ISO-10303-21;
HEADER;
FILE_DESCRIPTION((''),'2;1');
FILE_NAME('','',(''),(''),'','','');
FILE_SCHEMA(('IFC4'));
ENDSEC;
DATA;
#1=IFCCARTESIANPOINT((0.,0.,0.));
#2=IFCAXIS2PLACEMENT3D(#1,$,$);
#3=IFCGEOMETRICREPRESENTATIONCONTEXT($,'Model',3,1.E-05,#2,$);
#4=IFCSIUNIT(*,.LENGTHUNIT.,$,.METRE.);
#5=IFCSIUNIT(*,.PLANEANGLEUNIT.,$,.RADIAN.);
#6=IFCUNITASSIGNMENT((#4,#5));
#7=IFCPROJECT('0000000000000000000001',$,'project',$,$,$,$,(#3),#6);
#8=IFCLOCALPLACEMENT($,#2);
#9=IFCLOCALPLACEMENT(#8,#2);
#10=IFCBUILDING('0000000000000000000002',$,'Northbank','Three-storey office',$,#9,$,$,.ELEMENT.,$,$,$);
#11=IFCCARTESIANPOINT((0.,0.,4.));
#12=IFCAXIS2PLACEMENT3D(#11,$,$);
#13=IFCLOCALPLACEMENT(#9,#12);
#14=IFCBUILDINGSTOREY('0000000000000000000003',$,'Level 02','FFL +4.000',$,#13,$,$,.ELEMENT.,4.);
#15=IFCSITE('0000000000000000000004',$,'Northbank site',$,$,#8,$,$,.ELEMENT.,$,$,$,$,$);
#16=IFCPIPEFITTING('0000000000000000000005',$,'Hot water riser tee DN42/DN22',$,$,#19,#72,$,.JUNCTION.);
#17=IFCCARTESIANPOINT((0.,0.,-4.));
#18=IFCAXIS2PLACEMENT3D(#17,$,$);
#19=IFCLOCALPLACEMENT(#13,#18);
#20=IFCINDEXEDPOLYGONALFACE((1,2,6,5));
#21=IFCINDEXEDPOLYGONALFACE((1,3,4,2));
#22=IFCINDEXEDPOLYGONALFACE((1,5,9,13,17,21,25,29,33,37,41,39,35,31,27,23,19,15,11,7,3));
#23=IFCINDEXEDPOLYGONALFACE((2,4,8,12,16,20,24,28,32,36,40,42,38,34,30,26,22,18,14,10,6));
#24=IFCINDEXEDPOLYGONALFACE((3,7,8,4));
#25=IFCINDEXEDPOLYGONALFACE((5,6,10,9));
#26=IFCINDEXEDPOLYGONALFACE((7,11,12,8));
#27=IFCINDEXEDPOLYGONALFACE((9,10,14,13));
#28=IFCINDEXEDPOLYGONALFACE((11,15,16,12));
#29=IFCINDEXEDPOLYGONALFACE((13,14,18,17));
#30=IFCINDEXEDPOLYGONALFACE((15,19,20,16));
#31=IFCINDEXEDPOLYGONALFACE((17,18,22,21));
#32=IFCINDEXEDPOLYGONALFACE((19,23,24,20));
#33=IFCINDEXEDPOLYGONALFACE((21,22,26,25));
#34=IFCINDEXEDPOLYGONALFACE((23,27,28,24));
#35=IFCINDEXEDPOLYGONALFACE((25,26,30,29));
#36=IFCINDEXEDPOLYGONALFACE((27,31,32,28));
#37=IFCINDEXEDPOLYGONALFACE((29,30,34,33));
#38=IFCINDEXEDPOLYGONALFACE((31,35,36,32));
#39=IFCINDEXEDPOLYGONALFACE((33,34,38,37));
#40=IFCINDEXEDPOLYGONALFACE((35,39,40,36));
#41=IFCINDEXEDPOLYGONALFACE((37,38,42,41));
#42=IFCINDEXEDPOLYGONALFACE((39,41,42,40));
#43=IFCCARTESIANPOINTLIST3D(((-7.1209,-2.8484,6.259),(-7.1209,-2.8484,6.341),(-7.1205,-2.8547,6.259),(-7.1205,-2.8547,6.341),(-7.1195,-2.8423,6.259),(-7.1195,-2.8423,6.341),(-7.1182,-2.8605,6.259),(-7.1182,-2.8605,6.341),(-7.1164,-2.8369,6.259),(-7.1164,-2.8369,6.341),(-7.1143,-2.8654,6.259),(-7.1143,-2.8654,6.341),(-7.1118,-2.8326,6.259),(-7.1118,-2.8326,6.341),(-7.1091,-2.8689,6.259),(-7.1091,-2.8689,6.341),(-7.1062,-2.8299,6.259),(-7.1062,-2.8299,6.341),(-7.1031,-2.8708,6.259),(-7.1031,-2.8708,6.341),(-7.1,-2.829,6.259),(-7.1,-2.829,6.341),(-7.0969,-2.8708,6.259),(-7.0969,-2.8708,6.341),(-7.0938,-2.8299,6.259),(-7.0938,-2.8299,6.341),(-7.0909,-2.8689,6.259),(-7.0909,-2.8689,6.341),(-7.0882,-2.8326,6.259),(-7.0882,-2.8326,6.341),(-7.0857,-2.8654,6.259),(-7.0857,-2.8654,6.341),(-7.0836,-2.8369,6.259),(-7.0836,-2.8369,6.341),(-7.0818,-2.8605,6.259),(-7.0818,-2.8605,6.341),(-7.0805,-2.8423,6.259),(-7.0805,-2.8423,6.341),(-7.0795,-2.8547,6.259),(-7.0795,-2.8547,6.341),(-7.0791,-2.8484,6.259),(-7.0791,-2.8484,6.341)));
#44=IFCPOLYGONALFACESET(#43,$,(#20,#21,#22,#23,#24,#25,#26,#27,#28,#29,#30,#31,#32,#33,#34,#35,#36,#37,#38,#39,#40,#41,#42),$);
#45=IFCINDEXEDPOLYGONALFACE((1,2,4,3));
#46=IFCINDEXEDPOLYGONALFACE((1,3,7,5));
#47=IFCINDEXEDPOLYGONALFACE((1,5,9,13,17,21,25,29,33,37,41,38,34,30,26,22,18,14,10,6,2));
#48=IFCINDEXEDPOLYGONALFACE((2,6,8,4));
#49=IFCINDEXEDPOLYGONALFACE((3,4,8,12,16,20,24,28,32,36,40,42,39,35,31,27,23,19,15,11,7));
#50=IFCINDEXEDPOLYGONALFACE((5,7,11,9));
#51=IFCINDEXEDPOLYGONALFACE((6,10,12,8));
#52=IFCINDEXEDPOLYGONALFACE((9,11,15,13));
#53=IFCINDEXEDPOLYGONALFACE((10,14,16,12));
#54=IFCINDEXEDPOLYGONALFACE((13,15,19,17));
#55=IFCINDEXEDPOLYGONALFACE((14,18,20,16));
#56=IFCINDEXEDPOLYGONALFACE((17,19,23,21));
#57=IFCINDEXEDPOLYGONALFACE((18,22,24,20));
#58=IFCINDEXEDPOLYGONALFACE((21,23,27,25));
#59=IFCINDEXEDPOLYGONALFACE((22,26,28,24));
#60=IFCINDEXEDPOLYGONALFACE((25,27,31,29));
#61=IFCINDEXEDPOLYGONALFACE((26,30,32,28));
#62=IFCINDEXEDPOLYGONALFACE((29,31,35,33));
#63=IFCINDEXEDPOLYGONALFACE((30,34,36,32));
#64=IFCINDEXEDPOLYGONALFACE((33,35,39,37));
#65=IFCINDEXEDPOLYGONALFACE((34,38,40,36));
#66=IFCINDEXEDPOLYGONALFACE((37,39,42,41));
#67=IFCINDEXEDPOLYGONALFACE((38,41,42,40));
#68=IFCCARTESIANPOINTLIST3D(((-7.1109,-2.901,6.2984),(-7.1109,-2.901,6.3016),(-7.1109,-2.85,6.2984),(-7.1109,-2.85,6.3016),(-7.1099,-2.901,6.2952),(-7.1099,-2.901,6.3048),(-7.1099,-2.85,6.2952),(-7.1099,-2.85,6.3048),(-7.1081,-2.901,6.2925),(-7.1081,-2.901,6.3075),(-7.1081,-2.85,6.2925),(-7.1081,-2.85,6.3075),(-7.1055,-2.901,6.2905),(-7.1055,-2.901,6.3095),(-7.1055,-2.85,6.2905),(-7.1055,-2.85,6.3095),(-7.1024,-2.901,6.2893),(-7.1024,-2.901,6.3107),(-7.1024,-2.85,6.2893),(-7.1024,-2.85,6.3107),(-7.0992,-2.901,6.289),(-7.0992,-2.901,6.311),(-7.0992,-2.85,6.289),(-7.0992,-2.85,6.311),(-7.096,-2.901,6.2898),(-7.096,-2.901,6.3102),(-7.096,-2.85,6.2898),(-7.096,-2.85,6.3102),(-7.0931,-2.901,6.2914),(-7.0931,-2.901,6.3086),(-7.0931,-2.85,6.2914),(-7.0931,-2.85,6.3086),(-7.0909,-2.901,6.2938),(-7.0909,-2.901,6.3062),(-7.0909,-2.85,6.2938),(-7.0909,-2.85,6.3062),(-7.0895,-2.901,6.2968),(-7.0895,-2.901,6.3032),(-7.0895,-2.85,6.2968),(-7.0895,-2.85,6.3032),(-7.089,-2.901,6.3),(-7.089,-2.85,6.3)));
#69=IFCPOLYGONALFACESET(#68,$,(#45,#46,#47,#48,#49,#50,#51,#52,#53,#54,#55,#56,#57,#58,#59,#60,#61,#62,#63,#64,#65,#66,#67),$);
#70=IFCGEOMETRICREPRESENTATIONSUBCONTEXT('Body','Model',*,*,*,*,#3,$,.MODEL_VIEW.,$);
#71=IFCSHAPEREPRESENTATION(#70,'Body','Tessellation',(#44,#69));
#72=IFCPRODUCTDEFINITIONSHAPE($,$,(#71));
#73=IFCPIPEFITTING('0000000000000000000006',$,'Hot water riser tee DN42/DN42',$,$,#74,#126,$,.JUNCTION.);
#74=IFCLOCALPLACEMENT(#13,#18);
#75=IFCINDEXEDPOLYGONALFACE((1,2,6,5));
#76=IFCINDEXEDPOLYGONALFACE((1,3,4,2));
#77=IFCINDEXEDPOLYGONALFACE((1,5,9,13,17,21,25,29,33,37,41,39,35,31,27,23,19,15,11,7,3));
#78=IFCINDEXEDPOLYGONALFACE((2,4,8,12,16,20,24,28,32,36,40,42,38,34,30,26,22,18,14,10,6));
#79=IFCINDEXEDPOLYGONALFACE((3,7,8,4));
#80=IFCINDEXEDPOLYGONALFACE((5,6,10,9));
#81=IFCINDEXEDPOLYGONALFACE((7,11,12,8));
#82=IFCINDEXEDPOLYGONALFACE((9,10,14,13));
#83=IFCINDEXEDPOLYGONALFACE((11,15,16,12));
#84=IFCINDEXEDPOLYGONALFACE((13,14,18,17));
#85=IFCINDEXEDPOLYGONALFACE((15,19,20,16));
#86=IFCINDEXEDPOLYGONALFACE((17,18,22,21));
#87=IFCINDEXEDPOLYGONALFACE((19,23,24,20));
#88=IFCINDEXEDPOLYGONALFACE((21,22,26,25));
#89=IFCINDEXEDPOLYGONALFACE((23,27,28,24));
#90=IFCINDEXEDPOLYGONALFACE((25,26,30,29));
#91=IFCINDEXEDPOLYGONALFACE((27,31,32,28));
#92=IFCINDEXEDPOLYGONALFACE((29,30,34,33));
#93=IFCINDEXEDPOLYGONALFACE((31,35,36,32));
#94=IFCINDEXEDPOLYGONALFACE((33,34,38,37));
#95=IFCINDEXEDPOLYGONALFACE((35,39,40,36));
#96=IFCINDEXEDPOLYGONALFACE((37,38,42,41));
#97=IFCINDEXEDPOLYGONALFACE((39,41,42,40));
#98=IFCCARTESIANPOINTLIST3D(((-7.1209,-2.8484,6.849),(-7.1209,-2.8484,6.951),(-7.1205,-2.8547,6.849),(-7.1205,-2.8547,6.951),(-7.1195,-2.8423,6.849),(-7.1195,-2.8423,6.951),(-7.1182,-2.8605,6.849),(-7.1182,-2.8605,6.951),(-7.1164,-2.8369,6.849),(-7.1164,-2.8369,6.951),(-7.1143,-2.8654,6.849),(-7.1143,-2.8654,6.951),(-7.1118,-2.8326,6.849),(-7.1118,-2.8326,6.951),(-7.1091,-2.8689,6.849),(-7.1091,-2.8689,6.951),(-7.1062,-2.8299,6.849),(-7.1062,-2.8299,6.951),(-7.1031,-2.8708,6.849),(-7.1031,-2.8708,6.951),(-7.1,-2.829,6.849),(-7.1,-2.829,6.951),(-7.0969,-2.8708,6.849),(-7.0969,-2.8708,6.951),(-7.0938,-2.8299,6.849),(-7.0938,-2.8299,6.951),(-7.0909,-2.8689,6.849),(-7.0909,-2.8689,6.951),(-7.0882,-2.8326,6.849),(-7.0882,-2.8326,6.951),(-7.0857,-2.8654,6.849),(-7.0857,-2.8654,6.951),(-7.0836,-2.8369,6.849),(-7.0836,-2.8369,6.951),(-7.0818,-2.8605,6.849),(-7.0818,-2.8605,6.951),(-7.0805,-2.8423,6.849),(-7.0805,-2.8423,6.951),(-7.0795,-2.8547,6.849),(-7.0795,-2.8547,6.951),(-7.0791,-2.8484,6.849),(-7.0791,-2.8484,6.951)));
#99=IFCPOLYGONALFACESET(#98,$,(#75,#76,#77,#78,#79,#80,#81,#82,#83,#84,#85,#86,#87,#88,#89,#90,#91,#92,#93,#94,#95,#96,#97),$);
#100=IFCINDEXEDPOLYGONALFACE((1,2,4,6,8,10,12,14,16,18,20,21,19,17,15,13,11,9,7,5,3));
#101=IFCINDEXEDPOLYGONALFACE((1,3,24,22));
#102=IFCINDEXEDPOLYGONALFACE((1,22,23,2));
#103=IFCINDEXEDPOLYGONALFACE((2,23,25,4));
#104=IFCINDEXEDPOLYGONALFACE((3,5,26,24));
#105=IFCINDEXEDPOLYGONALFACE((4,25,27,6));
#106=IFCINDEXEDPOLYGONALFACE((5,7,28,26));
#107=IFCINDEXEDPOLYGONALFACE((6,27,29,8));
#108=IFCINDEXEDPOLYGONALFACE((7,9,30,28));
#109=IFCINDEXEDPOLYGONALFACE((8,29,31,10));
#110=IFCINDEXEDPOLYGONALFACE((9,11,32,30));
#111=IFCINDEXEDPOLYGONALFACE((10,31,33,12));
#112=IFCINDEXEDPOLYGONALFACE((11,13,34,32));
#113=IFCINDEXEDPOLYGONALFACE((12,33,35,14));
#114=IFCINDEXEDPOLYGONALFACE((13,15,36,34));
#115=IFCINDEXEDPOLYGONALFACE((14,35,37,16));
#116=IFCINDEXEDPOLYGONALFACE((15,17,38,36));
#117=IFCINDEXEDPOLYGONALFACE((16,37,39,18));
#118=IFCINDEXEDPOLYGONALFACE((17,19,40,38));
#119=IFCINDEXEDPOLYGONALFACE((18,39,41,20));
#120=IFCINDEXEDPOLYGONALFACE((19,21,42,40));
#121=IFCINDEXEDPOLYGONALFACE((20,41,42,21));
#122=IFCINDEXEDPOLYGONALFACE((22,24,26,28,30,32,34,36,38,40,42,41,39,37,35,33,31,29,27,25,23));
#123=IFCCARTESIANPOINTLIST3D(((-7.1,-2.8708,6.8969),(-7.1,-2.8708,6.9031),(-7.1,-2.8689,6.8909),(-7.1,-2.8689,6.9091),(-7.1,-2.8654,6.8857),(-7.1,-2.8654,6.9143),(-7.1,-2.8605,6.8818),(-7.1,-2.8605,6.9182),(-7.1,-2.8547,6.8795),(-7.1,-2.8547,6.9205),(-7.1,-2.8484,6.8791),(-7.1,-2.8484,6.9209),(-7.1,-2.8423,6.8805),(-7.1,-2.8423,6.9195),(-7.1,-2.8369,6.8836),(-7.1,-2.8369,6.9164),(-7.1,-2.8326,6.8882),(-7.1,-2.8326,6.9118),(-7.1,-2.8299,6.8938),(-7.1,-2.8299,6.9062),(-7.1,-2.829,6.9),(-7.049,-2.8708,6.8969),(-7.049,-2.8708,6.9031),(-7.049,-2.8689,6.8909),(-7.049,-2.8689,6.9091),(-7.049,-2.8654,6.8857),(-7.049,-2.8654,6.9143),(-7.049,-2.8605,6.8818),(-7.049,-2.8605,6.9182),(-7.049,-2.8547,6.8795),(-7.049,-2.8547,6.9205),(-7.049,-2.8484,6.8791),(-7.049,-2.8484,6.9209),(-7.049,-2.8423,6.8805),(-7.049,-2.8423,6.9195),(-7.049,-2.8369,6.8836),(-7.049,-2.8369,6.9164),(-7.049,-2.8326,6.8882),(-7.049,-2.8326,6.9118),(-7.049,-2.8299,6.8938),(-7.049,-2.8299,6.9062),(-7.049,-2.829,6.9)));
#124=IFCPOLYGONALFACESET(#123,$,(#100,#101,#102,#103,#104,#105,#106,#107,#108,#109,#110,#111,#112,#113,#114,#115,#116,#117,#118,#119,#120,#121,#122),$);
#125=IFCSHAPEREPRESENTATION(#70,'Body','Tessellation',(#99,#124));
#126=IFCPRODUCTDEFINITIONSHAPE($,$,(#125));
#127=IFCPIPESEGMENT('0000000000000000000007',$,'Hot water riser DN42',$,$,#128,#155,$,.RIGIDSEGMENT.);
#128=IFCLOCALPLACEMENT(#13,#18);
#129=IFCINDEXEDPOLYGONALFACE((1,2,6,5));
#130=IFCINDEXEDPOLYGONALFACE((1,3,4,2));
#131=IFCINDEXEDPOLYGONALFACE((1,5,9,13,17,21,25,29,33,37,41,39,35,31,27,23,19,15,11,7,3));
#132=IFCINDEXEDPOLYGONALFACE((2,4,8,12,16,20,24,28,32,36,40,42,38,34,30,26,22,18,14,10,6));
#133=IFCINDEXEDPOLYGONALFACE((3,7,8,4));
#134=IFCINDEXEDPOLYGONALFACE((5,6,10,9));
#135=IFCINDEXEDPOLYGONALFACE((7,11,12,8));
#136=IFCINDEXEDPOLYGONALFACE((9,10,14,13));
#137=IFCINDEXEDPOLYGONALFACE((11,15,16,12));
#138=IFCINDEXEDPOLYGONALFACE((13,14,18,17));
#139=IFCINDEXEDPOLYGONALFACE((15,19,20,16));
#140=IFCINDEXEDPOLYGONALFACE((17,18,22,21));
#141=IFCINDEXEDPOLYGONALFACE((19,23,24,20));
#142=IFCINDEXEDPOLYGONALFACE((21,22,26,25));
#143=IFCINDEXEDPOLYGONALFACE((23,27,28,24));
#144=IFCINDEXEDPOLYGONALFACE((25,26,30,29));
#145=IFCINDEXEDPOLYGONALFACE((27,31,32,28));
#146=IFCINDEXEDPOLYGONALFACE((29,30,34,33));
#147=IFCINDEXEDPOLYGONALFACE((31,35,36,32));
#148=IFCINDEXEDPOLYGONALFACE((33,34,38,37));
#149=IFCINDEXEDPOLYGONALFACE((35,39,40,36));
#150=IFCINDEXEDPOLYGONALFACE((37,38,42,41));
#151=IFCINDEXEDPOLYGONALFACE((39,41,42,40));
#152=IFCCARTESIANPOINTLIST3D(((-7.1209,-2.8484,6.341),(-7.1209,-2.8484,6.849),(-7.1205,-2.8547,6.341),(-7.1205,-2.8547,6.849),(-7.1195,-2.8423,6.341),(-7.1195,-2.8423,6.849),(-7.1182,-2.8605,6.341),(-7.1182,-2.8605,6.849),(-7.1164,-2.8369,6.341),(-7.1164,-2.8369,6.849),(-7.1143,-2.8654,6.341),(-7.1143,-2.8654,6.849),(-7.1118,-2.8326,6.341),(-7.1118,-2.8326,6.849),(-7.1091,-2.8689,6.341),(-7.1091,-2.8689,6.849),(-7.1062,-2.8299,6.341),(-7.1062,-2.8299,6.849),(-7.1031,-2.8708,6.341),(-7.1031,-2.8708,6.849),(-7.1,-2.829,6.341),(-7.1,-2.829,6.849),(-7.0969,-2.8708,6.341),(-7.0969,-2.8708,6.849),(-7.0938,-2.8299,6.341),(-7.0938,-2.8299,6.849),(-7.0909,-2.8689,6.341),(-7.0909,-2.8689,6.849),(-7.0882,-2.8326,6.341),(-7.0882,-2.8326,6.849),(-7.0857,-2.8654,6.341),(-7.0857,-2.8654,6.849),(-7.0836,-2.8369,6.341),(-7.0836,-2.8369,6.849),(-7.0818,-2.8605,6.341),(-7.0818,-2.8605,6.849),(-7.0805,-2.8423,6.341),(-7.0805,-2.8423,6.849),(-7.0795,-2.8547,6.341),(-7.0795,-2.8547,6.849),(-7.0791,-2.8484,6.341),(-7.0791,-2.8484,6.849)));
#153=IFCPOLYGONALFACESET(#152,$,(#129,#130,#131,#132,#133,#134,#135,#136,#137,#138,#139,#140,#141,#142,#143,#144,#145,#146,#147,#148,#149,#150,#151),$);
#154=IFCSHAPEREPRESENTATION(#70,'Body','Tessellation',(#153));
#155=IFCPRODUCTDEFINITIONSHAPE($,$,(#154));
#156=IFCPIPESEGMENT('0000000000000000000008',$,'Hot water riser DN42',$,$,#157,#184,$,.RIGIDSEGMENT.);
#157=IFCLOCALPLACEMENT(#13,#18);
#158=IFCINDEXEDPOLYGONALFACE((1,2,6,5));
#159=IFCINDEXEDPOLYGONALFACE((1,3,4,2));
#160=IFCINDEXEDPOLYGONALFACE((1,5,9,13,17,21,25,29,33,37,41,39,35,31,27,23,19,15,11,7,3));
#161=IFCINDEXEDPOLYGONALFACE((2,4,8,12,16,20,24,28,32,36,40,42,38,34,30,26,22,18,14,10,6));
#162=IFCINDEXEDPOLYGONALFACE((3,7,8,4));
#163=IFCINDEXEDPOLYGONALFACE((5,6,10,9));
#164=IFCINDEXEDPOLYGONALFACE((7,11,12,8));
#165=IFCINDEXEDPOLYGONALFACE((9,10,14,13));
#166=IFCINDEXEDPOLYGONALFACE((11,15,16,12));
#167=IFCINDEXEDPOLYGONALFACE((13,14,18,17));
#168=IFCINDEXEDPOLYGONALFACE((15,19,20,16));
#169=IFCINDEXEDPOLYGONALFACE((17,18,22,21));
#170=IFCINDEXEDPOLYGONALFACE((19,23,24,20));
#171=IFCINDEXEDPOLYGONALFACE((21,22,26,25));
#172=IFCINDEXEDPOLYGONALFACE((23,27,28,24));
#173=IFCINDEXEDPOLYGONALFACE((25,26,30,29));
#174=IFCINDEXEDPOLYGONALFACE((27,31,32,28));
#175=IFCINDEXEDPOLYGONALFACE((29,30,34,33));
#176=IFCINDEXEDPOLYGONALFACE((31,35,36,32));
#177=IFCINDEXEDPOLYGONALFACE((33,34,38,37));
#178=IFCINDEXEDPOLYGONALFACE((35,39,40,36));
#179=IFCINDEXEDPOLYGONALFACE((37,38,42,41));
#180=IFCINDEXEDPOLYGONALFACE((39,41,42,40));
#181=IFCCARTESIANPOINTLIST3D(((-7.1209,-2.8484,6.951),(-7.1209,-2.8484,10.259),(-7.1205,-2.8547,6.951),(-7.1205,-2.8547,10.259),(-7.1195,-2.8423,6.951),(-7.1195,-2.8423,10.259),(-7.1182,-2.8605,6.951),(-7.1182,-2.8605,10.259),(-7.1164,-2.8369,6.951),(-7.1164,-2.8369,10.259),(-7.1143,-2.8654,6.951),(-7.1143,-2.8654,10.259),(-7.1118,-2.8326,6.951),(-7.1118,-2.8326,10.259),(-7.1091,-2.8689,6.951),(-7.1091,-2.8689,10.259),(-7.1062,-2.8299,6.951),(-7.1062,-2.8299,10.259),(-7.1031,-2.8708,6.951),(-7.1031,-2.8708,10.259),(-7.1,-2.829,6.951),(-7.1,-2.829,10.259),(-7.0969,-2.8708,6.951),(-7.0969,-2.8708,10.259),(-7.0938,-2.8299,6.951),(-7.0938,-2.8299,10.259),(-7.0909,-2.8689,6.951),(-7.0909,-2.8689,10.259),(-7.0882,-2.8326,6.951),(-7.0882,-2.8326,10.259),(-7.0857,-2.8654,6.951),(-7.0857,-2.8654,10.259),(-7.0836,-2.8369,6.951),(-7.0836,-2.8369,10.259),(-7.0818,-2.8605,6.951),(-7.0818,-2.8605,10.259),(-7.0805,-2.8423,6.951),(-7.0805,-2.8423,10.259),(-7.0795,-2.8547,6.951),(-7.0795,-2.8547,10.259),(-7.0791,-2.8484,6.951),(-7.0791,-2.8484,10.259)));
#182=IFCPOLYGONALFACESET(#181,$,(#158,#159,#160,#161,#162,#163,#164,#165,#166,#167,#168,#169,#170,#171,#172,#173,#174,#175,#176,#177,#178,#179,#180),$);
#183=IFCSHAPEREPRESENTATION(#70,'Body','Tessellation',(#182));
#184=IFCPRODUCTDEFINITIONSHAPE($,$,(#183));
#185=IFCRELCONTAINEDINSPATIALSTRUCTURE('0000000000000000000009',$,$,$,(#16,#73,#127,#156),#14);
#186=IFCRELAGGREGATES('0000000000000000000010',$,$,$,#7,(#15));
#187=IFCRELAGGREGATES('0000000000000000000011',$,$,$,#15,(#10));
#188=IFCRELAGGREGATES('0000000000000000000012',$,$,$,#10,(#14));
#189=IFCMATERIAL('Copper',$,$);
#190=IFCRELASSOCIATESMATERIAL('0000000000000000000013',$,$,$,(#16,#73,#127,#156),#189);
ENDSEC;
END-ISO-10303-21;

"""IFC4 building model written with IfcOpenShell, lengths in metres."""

from ifc_helpers import new_model, si_unit, frame, origin, place, context, subcontext, project, spatial, circle, extrude, material, element, save


model = new_model("IFC4")

# Units and contexts
model_context = context("Model", 3, precision=1e-05, world=origin())
body_context = subcontext(model_context, "Body", "Model", "MODEL_VIEW")
ifc_project = project(units=[si_unit("LENGTHUNIT", "METRE"), si_unit("PLANEANGLEUNIT", "RADIAN")], contexts=[model_context])

# Site, building, storey
site_placement = place(None, origin())
site = spatial("IfcSite", under=ifc_project, at=site_placement, Name="Northbank site", CompositionType="ELEMENT")
building_placement = place(site_placement, origin())
building = spatial("IfcBuilding", under=site, at=building_placement, Name="Northbank", Description="Three-storey office", CompositionType="ELEMENT")
storey_placement = place(building_placement, frame((0.0, 0.0, 4.0)))
storey = spatial("IfcBuildingStorey", under=building, at=storey_placement, Name="Level 02", Description="FFL +4.000", CompositionType="ELEMENT", Elevation=4.0)

# Shared definitions
ifc_material = material(Name="Copper")

# Pipe fittings
pipe_fitting_1_placement = place(storey_placement, frame((0.0, 0.0, -4.0)))
element("IfcPipeFitting", 1, at=pipe_fitting_1_placement, inside=storey, material=ifc_material, Name="Hot water riser tee DN42/DN22", PredefinedType="JUNCTION", context=body_context, shape_type="SweptSolid", body=[
    extrude(circle(Radius=0.021), frame((-7.1, -2.85, 6.259), z_axis=(0.0, 0.0, 1.0), x_axis=(0.0, 1.0, 0.0)), (0.0, 0.0, 1.0), 0.082),
    extrude(circle(Radius=0.011), frame((-7.1, -2.85, 6.3), z_axis=(0.0, -1.0, 0.0), x_axis=(1.0, 0.0, 0.0)), (0.0, 0.0, 1.0), 0.051),
])
pipe_fitting_2_placement = place(storey_placement, frame((0.0, 0.0, -4.0)))
element("IfcPipeFitting", 2, at=pipe_fitting_2_placement, inside=storey, material=ifc_material, Name="Hot water riser tee DN42/DN42", PredefinedType="JUNCTION", context=body_context, shape_type="SweptSolid", body=[
    extrude(circle(Radius=0.021), frame((-7.1, -2.85, 6.849), z_axis=(0.0, 0.0, 1.0), x_axis=(0.0, 1.0, 0.0)), (0.0, 0.0, 1.0), 0.102),
    extrude(circle(Radius=0.021), frame((-7.1, -2.85, 6.9), z_axis=(1.0, 0.0, 0.0), x_axis=(0.0, 1.0, 0.0)), (0.0, 0.0, 1.0), 0.051),
])

# Pipe segments
pipe_segment_1_placement = place(storey_placement, frame((0.0, 0.0, -4.0)))
element("IfcPipeSegment", 3, at=pipe_segment_1_placement, inside=storey, material=ifc_material, Name="Hot water riser DN42", PredefinedType="RIGIDSEGMENT", context=body_context, shape_type="SweptSolid", body=[
    extrude(circle(Radius=0.021), frame((-7.1, -2.85, 6.341), z_axis=(0.0, 0.0, 1.0), x_axis=(0.0, 1.0, 0.0)), (0.0, 0.0, 1.0), 0.508),
])
pipe_segment_2_placement = place(storey_placement, frame((0.0, 0.0, -4.0)))
element("IfcPipeSegment", 4, at=pipe_segment_2_placement, inside=storey, material=ifc_material, Name="Hot water riser DN42", PredefinedType="RIGIDSEGMENT", context=body_context, shape_type="SweptSolid", body=[
    extrude(circle(Radius=0.021), frame((-7.1, -2.85, 6.951), z_axis=(0.0, 0.0, 1.0), x_axis=(0.0, 1.0, 0.0)), (0.0, 0.0, 1.0), 3.308),
])

save(model, "model.ifc")
